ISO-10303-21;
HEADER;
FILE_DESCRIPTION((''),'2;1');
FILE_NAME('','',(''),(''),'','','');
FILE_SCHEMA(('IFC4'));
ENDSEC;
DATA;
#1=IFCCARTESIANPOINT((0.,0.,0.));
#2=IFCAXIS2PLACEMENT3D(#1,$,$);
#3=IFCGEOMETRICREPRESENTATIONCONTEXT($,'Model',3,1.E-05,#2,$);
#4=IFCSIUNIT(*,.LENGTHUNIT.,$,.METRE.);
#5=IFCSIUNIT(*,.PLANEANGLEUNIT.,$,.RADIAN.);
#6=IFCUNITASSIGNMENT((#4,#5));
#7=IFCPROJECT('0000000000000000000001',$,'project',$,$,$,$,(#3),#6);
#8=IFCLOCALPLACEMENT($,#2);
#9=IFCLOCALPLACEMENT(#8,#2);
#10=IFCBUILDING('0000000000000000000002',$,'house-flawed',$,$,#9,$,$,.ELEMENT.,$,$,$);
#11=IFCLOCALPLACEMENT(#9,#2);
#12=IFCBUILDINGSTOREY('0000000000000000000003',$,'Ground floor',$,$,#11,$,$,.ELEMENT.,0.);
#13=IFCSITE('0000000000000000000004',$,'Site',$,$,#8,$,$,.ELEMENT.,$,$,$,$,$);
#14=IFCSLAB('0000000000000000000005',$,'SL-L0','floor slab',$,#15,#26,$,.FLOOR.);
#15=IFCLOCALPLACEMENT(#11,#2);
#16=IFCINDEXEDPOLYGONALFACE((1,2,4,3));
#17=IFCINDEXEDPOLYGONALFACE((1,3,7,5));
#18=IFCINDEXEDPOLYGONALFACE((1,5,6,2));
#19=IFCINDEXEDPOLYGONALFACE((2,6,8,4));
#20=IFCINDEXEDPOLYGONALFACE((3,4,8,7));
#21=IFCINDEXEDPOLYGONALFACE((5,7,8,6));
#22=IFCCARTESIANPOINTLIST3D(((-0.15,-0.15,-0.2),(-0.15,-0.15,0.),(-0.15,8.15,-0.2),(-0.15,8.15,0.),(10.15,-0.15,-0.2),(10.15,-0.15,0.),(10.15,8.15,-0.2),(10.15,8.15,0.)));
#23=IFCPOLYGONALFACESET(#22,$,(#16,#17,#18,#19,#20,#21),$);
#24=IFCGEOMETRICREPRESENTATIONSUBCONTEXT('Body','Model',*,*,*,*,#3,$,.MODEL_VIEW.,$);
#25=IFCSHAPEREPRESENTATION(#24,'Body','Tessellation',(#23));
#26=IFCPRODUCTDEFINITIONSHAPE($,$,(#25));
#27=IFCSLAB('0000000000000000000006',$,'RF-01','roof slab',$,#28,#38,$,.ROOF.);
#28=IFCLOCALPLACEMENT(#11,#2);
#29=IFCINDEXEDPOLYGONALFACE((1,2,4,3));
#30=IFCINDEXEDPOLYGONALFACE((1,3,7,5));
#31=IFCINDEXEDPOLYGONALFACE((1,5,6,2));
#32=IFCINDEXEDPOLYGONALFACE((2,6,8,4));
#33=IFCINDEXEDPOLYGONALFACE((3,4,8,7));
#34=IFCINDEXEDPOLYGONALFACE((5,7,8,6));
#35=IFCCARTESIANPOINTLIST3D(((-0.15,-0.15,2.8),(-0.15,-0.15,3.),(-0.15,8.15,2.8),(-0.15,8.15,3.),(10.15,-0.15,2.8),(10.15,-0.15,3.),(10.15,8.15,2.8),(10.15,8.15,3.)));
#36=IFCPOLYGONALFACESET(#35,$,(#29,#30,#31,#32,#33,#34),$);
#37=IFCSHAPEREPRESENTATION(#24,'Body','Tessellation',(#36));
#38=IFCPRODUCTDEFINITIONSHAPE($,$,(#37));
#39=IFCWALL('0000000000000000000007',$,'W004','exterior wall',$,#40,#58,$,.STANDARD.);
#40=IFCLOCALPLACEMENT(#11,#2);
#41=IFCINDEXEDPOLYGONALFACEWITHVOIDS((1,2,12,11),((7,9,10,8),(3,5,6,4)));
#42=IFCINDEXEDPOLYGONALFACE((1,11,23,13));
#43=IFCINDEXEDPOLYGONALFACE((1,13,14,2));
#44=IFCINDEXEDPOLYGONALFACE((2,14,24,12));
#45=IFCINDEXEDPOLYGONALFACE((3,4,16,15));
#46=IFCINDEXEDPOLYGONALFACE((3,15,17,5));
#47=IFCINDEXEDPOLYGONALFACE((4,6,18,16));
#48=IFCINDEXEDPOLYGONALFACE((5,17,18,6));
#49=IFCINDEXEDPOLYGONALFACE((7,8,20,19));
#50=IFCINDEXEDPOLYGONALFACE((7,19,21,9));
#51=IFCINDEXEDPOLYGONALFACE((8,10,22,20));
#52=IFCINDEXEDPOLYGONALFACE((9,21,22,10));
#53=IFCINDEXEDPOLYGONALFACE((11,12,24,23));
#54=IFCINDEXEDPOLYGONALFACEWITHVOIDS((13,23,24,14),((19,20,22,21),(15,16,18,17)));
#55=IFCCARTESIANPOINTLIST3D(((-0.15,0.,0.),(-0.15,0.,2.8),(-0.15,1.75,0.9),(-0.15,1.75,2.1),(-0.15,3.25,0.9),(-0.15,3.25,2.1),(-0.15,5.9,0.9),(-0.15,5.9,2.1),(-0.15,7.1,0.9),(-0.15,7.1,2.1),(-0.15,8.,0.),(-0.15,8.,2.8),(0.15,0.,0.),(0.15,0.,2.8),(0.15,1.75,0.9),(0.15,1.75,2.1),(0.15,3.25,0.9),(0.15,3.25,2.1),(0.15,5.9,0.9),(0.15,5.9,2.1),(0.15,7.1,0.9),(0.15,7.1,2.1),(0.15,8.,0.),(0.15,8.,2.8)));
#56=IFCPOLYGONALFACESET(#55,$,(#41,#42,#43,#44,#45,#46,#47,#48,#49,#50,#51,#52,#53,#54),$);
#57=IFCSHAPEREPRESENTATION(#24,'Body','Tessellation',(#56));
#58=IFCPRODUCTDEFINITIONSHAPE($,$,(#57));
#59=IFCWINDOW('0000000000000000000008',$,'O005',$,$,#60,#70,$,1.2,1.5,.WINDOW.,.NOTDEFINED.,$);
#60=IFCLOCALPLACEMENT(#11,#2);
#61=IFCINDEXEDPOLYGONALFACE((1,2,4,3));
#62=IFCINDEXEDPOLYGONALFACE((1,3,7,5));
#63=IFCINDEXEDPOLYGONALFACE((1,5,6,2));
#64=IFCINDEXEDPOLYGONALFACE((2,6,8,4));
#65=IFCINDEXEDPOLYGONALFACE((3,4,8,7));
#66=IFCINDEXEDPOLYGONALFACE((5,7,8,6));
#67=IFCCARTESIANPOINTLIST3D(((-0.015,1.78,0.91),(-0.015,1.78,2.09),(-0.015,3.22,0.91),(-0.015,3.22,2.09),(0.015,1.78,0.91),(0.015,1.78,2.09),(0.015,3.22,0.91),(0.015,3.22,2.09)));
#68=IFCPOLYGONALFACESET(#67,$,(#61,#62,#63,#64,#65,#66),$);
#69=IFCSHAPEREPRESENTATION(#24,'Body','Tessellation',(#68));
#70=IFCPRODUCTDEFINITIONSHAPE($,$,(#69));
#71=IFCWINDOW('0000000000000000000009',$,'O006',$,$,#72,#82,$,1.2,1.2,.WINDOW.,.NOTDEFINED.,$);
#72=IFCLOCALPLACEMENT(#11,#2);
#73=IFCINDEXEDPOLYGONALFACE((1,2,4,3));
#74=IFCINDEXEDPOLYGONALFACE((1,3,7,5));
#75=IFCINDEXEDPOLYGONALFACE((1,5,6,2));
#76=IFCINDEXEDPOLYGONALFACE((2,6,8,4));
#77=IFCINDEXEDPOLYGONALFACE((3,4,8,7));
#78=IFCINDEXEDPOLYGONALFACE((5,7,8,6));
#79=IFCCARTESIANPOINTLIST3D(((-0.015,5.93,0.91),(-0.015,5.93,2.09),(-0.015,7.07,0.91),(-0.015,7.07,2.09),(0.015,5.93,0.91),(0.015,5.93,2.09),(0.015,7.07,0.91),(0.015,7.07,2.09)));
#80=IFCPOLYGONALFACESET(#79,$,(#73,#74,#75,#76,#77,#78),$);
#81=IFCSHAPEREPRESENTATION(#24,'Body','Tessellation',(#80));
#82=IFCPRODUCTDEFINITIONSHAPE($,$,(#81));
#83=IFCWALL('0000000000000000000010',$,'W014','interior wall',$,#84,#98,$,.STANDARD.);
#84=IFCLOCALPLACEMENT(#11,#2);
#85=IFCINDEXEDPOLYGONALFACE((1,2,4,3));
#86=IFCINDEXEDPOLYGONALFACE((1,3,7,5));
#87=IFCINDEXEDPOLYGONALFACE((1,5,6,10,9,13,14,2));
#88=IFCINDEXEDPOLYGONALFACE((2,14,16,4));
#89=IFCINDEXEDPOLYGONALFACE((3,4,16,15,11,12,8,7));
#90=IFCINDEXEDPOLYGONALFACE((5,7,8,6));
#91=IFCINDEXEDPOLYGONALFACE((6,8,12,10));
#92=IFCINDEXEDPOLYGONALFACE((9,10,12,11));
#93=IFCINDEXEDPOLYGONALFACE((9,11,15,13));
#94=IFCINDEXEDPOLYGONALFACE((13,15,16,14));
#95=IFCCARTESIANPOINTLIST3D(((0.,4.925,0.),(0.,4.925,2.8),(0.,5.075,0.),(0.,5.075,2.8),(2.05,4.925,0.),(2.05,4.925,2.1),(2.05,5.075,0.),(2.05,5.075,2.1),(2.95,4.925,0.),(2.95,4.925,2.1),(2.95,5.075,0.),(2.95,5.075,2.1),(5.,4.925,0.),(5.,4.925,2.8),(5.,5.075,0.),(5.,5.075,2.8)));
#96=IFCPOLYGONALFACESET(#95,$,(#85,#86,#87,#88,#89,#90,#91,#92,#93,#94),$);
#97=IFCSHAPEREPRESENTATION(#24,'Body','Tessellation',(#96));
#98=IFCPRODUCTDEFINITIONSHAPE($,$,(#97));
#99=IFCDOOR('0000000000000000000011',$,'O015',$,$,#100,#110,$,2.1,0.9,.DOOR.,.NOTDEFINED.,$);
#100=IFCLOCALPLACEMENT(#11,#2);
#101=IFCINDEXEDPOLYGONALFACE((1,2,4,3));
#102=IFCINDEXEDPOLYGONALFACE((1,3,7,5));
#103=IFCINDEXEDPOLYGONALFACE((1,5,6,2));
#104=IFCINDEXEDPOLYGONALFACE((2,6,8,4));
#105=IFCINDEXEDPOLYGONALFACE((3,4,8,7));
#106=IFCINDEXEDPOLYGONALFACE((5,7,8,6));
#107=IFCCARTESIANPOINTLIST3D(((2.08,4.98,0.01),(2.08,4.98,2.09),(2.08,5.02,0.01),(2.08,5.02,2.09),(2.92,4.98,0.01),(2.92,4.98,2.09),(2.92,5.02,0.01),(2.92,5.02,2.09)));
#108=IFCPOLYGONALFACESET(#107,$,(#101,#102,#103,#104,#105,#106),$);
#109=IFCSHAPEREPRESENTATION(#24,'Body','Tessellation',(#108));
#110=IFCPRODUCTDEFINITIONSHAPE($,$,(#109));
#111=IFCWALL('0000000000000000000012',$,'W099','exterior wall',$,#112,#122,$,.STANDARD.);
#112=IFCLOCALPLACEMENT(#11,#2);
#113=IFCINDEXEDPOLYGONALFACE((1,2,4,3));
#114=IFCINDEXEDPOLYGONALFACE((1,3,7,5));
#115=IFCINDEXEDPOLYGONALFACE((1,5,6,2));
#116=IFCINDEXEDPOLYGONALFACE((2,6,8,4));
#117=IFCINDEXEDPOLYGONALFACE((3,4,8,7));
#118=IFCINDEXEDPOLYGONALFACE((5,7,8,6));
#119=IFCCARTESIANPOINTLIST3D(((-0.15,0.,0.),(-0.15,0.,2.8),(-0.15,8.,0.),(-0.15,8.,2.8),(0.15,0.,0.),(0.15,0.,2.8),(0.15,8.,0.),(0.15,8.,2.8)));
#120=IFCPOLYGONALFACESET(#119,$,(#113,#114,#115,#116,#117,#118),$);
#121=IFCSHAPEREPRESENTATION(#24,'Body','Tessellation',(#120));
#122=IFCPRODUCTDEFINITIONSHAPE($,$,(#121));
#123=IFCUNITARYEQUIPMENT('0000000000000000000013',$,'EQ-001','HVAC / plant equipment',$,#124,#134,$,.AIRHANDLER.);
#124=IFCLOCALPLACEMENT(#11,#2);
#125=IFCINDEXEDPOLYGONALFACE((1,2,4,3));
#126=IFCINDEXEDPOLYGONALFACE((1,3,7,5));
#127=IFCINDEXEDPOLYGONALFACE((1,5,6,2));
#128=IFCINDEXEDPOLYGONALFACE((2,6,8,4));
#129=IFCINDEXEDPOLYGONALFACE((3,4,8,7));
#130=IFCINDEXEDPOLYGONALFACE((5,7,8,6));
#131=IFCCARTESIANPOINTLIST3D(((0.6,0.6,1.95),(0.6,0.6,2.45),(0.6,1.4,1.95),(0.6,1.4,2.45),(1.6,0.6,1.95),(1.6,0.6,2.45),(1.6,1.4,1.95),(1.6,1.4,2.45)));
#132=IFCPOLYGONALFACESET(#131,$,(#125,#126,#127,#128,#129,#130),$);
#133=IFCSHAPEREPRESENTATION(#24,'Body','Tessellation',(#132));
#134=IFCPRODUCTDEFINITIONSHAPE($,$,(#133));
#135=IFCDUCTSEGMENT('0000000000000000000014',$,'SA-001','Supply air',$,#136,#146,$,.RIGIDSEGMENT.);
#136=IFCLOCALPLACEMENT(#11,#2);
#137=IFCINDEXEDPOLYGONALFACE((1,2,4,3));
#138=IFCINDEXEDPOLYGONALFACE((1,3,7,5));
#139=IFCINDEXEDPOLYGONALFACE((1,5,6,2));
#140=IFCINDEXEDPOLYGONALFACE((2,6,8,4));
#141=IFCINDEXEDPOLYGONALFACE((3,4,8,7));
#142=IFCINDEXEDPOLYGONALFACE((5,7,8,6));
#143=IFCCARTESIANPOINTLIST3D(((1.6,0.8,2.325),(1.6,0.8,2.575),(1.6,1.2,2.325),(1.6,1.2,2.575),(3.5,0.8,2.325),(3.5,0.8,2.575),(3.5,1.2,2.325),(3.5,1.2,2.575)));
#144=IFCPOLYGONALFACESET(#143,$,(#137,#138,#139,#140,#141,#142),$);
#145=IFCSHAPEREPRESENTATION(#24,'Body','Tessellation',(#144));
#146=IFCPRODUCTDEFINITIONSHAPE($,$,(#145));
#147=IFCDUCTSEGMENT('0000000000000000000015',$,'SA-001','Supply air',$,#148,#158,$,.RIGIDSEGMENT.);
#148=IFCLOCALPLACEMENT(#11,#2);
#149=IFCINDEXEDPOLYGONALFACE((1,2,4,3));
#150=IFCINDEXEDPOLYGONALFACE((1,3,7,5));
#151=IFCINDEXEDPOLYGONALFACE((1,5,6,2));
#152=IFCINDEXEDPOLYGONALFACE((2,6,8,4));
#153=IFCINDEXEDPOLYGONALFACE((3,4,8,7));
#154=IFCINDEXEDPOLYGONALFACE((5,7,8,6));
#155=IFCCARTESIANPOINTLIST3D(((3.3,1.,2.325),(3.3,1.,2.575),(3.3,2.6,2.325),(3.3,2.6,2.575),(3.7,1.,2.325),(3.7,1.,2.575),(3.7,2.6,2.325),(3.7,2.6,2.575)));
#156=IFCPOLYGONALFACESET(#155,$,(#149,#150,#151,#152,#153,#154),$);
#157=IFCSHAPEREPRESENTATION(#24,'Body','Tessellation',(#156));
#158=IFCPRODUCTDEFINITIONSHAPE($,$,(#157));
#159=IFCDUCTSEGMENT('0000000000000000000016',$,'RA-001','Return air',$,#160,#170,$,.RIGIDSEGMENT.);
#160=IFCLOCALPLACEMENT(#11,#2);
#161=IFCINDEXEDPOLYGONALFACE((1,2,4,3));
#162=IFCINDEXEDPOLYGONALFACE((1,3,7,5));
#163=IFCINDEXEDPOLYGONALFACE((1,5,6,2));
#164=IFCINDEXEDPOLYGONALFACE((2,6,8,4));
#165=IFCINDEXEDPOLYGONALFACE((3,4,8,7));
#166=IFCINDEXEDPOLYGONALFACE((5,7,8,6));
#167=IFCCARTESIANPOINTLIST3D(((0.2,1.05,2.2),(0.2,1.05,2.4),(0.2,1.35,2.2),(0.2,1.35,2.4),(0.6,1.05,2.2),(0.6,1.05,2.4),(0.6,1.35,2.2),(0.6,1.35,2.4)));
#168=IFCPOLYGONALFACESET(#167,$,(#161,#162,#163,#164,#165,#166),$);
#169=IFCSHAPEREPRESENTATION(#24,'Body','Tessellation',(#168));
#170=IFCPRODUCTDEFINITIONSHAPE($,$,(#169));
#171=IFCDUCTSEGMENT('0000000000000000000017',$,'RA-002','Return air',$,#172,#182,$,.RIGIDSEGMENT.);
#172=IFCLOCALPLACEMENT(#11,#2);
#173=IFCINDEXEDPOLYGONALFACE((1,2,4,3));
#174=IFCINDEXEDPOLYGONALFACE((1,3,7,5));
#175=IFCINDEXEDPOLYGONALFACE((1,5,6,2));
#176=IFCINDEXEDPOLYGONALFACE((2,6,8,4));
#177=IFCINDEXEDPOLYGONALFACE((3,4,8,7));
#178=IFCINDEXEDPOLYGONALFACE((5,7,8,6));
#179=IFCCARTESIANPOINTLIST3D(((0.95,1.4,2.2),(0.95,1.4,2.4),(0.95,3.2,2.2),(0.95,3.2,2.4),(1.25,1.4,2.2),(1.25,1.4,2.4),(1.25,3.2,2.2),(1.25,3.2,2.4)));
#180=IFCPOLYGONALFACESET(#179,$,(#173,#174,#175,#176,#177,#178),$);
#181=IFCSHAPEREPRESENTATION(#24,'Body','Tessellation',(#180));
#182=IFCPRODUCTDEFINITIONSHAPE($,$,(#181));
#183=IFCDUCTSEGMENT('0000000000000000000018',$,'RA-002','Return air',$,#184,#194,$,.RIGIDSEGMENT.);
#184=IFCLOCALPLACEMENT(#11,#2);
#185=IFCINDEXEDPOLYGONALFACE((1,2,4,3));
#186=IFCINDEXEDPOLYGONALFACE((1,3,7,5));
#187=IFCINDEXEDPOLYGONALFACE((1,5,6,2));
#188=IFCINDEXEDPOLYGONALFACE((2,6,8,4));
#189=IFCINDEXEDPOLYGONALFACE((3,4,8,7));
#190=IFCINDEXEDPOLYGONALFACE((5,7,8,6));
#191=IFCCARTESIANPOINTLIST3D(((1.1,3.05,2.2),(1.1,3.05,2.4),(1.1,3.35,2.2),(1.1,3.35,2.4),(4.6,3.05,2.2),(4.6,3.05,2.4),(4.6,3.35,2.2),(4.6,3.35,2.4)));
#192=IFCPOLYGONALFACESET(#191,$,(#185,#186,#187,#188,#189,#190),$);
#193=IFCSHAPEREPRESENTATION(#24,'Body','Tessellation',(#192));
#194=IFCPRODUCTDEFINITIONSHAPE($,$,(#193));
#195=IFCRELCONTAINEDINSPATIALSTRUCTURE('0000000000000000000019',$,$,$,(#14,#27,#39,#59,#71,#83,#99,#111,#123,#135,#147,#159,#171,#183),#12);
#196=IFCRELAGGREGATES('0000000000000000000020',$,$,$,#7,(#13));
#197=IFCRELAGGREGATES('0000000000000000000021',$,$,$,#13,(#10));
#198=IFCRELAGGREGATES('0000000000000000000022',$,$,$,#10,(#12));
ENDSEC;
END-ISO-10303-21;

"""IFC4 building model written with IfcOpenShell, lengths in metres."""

from ifc_helpers import new_model, si_unit, frame, origin, origin_2d, place, context, subcontext, project, spatial, polyline, rectangle, outline, extrude, element, fill, save


model = new_model("IFC4")

# Units and contexts
model_context = context("Model", 3, precision=1e-05, world=origin())
body_context = subcontext(model_context, "Body", "Model", "MODEL_VIEW")
ifc_project = project(units=[si_unit("LENGTHUNIT", "METRE"), si_unit("PLANEANGLEUNIT", "RADIAN")], contexts=[model_context])

# Site, building, storey
site_placement = place(None, origin())
site = spatial("IfcSite", under=ifc_project, at=site_placement, Name="Site", CompositionType="ELEMENT")
building_placement = place(site_placement, origin())
building = spatial("IfcBuilding", under=site, at=building_placement, Name="house-flawed", CompositionType="ELEMENT")
storey_placement = place(building_placement, origin())
storey = spatial("IfcBuildingStorey", under=building, at=storey_placement, Name="Ground floor", CompositionType="ELEMENT", Elevation=0.0)

# Slabs
slab_1_placement = place(storey_placement, frame((0.0, 0.0, -0.2)))
element("IfcSlab", 1, at=slab_1_placement, inside=storey, Name="SL-L0", Description="floor slab", PredefinedType="FLOOR", context=body_context, shape_type="SweptSolid", body=[
    extrude(outline(polyline([(-0.15, 8.15), (10.15, 8.15), (10.15, -0.15), (-0.15, -0.15), (-0.15, 8.15)])), origin(), (0.0, 0.0, 1.0), 0.2),
])
slab_2_placement = place(storey_placement, frame((0.0, 0.0, 2.8)))
element("IfcSlab", 2, at=slab_2_placement, inside=storey, Name="RF-01", Description="roof slab", PredefinedType="ROOF", context=body_context, shape_type="SweptSolid", body=[
    extrude(outline(polyline([(-0.15, 8.15), (10.15, 8.15), (10.15, -0.15), (-0.15, -0.15), (-0.15, 8.15)])), origin(), (0.0, 0.0, 1.0), 0.2),
])

# Wall, openings, windows
wall_1_placement = place(storey_placement, frame((0.0, 4.0, 0.0), z_axis=(0.0, 0.0, 1.0), x_axis=(0.0, 1.0, 0.0)))
wall_1 = element("IfcWall", 3, at=wall_1_placement, inside=storey, Name="W004", Description="exterior wall", PredefinedType="STANDARD", context=body_context, shape_type="SweptSolid", body=[
    extrude(rectangle(XDim=8.0, YDim=0.3, at=origin_2d()), origin(), (0.0, 0.0, 1.0), 2.8),
])
opening_1_placement = place(wall_1_placement, frame((-1.5, 0.0, 0.9)))
opening_1 = element("IfcOpeningElement", 4, at=opening_1_placement, cuts=wall_1, PredefinedType="OPENING", context=body_context, shape_type="SweptSolid", body=[
    extrude(rectangle(XDim=1.5, YDim=0.36, at=origin_2d()), origin(), (0.0, 0.0, 1.0), 1.2),
])
opening_2_placement = place(wall_1_placement, frame((2.5, 0.0, 0.9)))
opening_2 = element("IfcOpeningElement", 5, at=opening_2_placement, cuts=wall_1, PredefinedType="OPENING", context=body_context, shape_type="SweptSolid", body=[
    extrude(rectangle(XDim=1.2, YDim=0.36, at=origin_2d()), origin(), (0.0, 0.0, 1.0), 1.2),
])
window_1_placement = place(wall_1_placement, frame((-1.5, 0.0, 0.9)))
window_1 = element("IfcWindow", 6, at=window_1_placement, inside=storey, Name="O005", OverallHeight=1.2, OverallWidth=1.5, PartitioningType="NOTDEFINED", PredefinedType="WINDOW", context=body_context, shape_type="SweptSolid", body=[
    extrude(rectangle(XDim=1.44, YDim=0.03, at=origin_2d()), frame((0.0, 0.0, 0.01)), (0.0, 0.0, 1.0), 1.18),
])
fill(opening_1, window_1)
window_2_placement = place(wall_1_placement, frame((2.5, 0.0, 0.9)))
window_2 = element("IfcWindow", 7, at=window_2_placement, inside=storey, Name="O006", OverallHeight=1.2, OverallWidth=1.2, PartitioningType="NOTDEFINED", PredefinedType="WINDOW", context=body_context, shape_type="SweptSolid", body=[
    extrude(rectangle(XDim=1.14, YDim=0.03, at=origin_2d()), frame((0.0, 0.0, 0.01)), (0.0, 0.0, 1.0), 1.18),
])
fill(opening_2, window_2)

# Wall, opening, door
wall_2_placement = place(storey_placement, frame((2.5, 5.0, 0.0), z_axis=(0.0, 0.0, 1.0), x_axis=(1.0, 0.0, 0.0)))
wall_2 = element("IfcWall", 8, at=wall_2_placement, inside=storey, Name="W014", Description="interior wall", PredefinedType="STANDARD", context=body_context, shape_type="SweptSolid", body=[
    extrude(rectangle(XDim=5.0, YDim=0.15, at=origin_2d()), origin(), (0.0, 0.0, 1.0), 2.8),
])
opening_3_placement = place(wall_2_placement, origin())
opening_3 = element("IfcOpeningElement", 9, at=opening_3_placement, cuts=wall_2, PredefinedType="OPENING", context=body_context, shape_type="SweptSolid", body=[
    extrude(rectangle(XDim=0.9, YDim=0.18, at=origin_2d()), origin(), (0.0, 0.0, 1.0), 2.1),
])
door_placement = place(wall_2_placement, origin())
door = element("IfcDoor", 10, at=door_placement, inside=storey, Name="O015", OperationType="NOTDEFINED", OverallHeight=2.1, OverallWidth=0.9, PredefinedType="DOOR", context=body_context, shape_type="SweptSolid", body=[
    extrude(rectangle(XDim=0.84, YDim=0.04, at=origin_2d()), frame((0.0, 0.0, 0.01)), (0.0, 0.0, 1.0), 2.08),
])
fill(opening_3, door)

# Wall
wall_3_placement = place(storey_placement, frame((0.0, 4.0, 0.0), z_axis=(0.0, 0.0, 1.0), x_axis=(0.0, 1.0, 0.0)))
element("IfcWall", 11, at=wall_3_placement, inside=storey, Name="W099", Description="exterior wall", PredefinedType="STANDARD", context=body_context, shape_type="SweptSolid", body=[
    extrude(rectangle(XDim=8.0, YDim=0.3, at=origin_2d()), origin(), (0.0, 0.0, 1.0), 2.8),
])

# Unitary equipment
unitary_equipment_placement = place(storey_placement, frame((1.1, 1.0, 1.95), z_axis=(0.0, 0.0, 1.0), x_axis=(1.0, 0.0, 0.0)))
element("IfcUnitaryEquipment", 12, at=unitary_equipment_placement, inside=storey, Name="EQ-001", Description="HVAC / plant equipment", PredefinedType="AIRHANDLER", context=body_context, shape_type="SweptSolid", body=[
    extrude(rectangle(XDim=1.0, YDim=0.8, at=origin_2d()), origin(), (0.0, 0.0, 1.0), 0.5),
])

# Duct segments
duct_segment_1_placement = place(storey_placement, frame((1.6, 1.0, 2.45), z_axis=(1.0, 0.0, 0.0), x_axis=(0.0, 1.0, 0.0)))
element("IfcDuctSegment", 13, at=duct_segment_1_placement, inside=storey, Name="SA-001", Description="Supply air", PredefinedType="RIGIDSEGMENT", context=body_context, shape_type="SweptSolid", body=[
    extrude(rectangle(XDim=0.4, YDim=0.25, at=origin_2d()), origin(), (0.0, 0.0, 1.0), 1.9),
])
duct_segment_2_placement = place(storey_placement, frame((3.5, 1.0, 2.45), z_axis=(0.0, 1.0, 0.0), x_axis=(-1.0, 0.0, 0.0)))
element("IfcDuctSegment", 14, at=duct_segment_2_placement, inside=storey, Name="SA-001", Description="Supply air", PredefinedType="RIGIDSEGMENT", context=body_context, shape_type="SweptSolid", body=[
    extrude(rectangle(XDim=0.4, YDim=0.25, at=origin_2d()), origin(), (0.0, 0.0, 1.0), 1.6),
])
duct_segment_3_placement = place(storey_placement, frame((0.6, 1.2, 2.3), z_axis=(-1.0, 0.0, 0.0), x_axis=(0.0, -1.0, 0.0)))
element("IfcDuctSegment", 15, at=duct_segment_3_placement, inside=storey, Name="RA-001", Description="Return air", PredefinedType="RIGIDSEGMENT", context=body_context, shape_type="SweptSolid", body=[
    extrude(rectangle(XDim=0.3, YDim=0.2, at=origin_2d()), origin(), (0.0, 0.0, 1.0), 0.4),
])
duct_segment_4_placement = place(storey_placement, frame((1.1, 1.4, 2.3), z_axis=(0.0, 1.0, 0.0), x_axis=(-1.0, 0.0, 0.0)))
element("IfcDuctSegment", 16, at=duct_segment_4_placement, inside=storey, Name="RA-002", Description="Return air", PredefinedType="RIGIDSEGMENT", context=body_context, shape_type="SweptSolid", body=[
    extrude(rectangle(XDim=0.3, YDim=0.2, at=origin_2d()), origin(), (0.0, 0.0, 1.0), 1.8),
])
duct_segment_5_placement = place(storey_placement, frame((1.1, 3.2, 2.3), z_axis=(1.0, 0.0, 0.0), x_axis=(0.0, 1.0, 0.0)))
element("IfcDuctSegment", 17, at=duct_segment_5_placement, inside=storey, Name="RA-002", Description="Return air", PredefinedType="RIGIDSEGMENT", context=body_context, shape_type="SweptSolid", body=[
    extrude(rectangle(XDim=0.3, YDim=0.2, at=origin_2d()), origin(), (0.0, 0.0, 1.0), 3.5),
])

save(model, "model.ifc")
